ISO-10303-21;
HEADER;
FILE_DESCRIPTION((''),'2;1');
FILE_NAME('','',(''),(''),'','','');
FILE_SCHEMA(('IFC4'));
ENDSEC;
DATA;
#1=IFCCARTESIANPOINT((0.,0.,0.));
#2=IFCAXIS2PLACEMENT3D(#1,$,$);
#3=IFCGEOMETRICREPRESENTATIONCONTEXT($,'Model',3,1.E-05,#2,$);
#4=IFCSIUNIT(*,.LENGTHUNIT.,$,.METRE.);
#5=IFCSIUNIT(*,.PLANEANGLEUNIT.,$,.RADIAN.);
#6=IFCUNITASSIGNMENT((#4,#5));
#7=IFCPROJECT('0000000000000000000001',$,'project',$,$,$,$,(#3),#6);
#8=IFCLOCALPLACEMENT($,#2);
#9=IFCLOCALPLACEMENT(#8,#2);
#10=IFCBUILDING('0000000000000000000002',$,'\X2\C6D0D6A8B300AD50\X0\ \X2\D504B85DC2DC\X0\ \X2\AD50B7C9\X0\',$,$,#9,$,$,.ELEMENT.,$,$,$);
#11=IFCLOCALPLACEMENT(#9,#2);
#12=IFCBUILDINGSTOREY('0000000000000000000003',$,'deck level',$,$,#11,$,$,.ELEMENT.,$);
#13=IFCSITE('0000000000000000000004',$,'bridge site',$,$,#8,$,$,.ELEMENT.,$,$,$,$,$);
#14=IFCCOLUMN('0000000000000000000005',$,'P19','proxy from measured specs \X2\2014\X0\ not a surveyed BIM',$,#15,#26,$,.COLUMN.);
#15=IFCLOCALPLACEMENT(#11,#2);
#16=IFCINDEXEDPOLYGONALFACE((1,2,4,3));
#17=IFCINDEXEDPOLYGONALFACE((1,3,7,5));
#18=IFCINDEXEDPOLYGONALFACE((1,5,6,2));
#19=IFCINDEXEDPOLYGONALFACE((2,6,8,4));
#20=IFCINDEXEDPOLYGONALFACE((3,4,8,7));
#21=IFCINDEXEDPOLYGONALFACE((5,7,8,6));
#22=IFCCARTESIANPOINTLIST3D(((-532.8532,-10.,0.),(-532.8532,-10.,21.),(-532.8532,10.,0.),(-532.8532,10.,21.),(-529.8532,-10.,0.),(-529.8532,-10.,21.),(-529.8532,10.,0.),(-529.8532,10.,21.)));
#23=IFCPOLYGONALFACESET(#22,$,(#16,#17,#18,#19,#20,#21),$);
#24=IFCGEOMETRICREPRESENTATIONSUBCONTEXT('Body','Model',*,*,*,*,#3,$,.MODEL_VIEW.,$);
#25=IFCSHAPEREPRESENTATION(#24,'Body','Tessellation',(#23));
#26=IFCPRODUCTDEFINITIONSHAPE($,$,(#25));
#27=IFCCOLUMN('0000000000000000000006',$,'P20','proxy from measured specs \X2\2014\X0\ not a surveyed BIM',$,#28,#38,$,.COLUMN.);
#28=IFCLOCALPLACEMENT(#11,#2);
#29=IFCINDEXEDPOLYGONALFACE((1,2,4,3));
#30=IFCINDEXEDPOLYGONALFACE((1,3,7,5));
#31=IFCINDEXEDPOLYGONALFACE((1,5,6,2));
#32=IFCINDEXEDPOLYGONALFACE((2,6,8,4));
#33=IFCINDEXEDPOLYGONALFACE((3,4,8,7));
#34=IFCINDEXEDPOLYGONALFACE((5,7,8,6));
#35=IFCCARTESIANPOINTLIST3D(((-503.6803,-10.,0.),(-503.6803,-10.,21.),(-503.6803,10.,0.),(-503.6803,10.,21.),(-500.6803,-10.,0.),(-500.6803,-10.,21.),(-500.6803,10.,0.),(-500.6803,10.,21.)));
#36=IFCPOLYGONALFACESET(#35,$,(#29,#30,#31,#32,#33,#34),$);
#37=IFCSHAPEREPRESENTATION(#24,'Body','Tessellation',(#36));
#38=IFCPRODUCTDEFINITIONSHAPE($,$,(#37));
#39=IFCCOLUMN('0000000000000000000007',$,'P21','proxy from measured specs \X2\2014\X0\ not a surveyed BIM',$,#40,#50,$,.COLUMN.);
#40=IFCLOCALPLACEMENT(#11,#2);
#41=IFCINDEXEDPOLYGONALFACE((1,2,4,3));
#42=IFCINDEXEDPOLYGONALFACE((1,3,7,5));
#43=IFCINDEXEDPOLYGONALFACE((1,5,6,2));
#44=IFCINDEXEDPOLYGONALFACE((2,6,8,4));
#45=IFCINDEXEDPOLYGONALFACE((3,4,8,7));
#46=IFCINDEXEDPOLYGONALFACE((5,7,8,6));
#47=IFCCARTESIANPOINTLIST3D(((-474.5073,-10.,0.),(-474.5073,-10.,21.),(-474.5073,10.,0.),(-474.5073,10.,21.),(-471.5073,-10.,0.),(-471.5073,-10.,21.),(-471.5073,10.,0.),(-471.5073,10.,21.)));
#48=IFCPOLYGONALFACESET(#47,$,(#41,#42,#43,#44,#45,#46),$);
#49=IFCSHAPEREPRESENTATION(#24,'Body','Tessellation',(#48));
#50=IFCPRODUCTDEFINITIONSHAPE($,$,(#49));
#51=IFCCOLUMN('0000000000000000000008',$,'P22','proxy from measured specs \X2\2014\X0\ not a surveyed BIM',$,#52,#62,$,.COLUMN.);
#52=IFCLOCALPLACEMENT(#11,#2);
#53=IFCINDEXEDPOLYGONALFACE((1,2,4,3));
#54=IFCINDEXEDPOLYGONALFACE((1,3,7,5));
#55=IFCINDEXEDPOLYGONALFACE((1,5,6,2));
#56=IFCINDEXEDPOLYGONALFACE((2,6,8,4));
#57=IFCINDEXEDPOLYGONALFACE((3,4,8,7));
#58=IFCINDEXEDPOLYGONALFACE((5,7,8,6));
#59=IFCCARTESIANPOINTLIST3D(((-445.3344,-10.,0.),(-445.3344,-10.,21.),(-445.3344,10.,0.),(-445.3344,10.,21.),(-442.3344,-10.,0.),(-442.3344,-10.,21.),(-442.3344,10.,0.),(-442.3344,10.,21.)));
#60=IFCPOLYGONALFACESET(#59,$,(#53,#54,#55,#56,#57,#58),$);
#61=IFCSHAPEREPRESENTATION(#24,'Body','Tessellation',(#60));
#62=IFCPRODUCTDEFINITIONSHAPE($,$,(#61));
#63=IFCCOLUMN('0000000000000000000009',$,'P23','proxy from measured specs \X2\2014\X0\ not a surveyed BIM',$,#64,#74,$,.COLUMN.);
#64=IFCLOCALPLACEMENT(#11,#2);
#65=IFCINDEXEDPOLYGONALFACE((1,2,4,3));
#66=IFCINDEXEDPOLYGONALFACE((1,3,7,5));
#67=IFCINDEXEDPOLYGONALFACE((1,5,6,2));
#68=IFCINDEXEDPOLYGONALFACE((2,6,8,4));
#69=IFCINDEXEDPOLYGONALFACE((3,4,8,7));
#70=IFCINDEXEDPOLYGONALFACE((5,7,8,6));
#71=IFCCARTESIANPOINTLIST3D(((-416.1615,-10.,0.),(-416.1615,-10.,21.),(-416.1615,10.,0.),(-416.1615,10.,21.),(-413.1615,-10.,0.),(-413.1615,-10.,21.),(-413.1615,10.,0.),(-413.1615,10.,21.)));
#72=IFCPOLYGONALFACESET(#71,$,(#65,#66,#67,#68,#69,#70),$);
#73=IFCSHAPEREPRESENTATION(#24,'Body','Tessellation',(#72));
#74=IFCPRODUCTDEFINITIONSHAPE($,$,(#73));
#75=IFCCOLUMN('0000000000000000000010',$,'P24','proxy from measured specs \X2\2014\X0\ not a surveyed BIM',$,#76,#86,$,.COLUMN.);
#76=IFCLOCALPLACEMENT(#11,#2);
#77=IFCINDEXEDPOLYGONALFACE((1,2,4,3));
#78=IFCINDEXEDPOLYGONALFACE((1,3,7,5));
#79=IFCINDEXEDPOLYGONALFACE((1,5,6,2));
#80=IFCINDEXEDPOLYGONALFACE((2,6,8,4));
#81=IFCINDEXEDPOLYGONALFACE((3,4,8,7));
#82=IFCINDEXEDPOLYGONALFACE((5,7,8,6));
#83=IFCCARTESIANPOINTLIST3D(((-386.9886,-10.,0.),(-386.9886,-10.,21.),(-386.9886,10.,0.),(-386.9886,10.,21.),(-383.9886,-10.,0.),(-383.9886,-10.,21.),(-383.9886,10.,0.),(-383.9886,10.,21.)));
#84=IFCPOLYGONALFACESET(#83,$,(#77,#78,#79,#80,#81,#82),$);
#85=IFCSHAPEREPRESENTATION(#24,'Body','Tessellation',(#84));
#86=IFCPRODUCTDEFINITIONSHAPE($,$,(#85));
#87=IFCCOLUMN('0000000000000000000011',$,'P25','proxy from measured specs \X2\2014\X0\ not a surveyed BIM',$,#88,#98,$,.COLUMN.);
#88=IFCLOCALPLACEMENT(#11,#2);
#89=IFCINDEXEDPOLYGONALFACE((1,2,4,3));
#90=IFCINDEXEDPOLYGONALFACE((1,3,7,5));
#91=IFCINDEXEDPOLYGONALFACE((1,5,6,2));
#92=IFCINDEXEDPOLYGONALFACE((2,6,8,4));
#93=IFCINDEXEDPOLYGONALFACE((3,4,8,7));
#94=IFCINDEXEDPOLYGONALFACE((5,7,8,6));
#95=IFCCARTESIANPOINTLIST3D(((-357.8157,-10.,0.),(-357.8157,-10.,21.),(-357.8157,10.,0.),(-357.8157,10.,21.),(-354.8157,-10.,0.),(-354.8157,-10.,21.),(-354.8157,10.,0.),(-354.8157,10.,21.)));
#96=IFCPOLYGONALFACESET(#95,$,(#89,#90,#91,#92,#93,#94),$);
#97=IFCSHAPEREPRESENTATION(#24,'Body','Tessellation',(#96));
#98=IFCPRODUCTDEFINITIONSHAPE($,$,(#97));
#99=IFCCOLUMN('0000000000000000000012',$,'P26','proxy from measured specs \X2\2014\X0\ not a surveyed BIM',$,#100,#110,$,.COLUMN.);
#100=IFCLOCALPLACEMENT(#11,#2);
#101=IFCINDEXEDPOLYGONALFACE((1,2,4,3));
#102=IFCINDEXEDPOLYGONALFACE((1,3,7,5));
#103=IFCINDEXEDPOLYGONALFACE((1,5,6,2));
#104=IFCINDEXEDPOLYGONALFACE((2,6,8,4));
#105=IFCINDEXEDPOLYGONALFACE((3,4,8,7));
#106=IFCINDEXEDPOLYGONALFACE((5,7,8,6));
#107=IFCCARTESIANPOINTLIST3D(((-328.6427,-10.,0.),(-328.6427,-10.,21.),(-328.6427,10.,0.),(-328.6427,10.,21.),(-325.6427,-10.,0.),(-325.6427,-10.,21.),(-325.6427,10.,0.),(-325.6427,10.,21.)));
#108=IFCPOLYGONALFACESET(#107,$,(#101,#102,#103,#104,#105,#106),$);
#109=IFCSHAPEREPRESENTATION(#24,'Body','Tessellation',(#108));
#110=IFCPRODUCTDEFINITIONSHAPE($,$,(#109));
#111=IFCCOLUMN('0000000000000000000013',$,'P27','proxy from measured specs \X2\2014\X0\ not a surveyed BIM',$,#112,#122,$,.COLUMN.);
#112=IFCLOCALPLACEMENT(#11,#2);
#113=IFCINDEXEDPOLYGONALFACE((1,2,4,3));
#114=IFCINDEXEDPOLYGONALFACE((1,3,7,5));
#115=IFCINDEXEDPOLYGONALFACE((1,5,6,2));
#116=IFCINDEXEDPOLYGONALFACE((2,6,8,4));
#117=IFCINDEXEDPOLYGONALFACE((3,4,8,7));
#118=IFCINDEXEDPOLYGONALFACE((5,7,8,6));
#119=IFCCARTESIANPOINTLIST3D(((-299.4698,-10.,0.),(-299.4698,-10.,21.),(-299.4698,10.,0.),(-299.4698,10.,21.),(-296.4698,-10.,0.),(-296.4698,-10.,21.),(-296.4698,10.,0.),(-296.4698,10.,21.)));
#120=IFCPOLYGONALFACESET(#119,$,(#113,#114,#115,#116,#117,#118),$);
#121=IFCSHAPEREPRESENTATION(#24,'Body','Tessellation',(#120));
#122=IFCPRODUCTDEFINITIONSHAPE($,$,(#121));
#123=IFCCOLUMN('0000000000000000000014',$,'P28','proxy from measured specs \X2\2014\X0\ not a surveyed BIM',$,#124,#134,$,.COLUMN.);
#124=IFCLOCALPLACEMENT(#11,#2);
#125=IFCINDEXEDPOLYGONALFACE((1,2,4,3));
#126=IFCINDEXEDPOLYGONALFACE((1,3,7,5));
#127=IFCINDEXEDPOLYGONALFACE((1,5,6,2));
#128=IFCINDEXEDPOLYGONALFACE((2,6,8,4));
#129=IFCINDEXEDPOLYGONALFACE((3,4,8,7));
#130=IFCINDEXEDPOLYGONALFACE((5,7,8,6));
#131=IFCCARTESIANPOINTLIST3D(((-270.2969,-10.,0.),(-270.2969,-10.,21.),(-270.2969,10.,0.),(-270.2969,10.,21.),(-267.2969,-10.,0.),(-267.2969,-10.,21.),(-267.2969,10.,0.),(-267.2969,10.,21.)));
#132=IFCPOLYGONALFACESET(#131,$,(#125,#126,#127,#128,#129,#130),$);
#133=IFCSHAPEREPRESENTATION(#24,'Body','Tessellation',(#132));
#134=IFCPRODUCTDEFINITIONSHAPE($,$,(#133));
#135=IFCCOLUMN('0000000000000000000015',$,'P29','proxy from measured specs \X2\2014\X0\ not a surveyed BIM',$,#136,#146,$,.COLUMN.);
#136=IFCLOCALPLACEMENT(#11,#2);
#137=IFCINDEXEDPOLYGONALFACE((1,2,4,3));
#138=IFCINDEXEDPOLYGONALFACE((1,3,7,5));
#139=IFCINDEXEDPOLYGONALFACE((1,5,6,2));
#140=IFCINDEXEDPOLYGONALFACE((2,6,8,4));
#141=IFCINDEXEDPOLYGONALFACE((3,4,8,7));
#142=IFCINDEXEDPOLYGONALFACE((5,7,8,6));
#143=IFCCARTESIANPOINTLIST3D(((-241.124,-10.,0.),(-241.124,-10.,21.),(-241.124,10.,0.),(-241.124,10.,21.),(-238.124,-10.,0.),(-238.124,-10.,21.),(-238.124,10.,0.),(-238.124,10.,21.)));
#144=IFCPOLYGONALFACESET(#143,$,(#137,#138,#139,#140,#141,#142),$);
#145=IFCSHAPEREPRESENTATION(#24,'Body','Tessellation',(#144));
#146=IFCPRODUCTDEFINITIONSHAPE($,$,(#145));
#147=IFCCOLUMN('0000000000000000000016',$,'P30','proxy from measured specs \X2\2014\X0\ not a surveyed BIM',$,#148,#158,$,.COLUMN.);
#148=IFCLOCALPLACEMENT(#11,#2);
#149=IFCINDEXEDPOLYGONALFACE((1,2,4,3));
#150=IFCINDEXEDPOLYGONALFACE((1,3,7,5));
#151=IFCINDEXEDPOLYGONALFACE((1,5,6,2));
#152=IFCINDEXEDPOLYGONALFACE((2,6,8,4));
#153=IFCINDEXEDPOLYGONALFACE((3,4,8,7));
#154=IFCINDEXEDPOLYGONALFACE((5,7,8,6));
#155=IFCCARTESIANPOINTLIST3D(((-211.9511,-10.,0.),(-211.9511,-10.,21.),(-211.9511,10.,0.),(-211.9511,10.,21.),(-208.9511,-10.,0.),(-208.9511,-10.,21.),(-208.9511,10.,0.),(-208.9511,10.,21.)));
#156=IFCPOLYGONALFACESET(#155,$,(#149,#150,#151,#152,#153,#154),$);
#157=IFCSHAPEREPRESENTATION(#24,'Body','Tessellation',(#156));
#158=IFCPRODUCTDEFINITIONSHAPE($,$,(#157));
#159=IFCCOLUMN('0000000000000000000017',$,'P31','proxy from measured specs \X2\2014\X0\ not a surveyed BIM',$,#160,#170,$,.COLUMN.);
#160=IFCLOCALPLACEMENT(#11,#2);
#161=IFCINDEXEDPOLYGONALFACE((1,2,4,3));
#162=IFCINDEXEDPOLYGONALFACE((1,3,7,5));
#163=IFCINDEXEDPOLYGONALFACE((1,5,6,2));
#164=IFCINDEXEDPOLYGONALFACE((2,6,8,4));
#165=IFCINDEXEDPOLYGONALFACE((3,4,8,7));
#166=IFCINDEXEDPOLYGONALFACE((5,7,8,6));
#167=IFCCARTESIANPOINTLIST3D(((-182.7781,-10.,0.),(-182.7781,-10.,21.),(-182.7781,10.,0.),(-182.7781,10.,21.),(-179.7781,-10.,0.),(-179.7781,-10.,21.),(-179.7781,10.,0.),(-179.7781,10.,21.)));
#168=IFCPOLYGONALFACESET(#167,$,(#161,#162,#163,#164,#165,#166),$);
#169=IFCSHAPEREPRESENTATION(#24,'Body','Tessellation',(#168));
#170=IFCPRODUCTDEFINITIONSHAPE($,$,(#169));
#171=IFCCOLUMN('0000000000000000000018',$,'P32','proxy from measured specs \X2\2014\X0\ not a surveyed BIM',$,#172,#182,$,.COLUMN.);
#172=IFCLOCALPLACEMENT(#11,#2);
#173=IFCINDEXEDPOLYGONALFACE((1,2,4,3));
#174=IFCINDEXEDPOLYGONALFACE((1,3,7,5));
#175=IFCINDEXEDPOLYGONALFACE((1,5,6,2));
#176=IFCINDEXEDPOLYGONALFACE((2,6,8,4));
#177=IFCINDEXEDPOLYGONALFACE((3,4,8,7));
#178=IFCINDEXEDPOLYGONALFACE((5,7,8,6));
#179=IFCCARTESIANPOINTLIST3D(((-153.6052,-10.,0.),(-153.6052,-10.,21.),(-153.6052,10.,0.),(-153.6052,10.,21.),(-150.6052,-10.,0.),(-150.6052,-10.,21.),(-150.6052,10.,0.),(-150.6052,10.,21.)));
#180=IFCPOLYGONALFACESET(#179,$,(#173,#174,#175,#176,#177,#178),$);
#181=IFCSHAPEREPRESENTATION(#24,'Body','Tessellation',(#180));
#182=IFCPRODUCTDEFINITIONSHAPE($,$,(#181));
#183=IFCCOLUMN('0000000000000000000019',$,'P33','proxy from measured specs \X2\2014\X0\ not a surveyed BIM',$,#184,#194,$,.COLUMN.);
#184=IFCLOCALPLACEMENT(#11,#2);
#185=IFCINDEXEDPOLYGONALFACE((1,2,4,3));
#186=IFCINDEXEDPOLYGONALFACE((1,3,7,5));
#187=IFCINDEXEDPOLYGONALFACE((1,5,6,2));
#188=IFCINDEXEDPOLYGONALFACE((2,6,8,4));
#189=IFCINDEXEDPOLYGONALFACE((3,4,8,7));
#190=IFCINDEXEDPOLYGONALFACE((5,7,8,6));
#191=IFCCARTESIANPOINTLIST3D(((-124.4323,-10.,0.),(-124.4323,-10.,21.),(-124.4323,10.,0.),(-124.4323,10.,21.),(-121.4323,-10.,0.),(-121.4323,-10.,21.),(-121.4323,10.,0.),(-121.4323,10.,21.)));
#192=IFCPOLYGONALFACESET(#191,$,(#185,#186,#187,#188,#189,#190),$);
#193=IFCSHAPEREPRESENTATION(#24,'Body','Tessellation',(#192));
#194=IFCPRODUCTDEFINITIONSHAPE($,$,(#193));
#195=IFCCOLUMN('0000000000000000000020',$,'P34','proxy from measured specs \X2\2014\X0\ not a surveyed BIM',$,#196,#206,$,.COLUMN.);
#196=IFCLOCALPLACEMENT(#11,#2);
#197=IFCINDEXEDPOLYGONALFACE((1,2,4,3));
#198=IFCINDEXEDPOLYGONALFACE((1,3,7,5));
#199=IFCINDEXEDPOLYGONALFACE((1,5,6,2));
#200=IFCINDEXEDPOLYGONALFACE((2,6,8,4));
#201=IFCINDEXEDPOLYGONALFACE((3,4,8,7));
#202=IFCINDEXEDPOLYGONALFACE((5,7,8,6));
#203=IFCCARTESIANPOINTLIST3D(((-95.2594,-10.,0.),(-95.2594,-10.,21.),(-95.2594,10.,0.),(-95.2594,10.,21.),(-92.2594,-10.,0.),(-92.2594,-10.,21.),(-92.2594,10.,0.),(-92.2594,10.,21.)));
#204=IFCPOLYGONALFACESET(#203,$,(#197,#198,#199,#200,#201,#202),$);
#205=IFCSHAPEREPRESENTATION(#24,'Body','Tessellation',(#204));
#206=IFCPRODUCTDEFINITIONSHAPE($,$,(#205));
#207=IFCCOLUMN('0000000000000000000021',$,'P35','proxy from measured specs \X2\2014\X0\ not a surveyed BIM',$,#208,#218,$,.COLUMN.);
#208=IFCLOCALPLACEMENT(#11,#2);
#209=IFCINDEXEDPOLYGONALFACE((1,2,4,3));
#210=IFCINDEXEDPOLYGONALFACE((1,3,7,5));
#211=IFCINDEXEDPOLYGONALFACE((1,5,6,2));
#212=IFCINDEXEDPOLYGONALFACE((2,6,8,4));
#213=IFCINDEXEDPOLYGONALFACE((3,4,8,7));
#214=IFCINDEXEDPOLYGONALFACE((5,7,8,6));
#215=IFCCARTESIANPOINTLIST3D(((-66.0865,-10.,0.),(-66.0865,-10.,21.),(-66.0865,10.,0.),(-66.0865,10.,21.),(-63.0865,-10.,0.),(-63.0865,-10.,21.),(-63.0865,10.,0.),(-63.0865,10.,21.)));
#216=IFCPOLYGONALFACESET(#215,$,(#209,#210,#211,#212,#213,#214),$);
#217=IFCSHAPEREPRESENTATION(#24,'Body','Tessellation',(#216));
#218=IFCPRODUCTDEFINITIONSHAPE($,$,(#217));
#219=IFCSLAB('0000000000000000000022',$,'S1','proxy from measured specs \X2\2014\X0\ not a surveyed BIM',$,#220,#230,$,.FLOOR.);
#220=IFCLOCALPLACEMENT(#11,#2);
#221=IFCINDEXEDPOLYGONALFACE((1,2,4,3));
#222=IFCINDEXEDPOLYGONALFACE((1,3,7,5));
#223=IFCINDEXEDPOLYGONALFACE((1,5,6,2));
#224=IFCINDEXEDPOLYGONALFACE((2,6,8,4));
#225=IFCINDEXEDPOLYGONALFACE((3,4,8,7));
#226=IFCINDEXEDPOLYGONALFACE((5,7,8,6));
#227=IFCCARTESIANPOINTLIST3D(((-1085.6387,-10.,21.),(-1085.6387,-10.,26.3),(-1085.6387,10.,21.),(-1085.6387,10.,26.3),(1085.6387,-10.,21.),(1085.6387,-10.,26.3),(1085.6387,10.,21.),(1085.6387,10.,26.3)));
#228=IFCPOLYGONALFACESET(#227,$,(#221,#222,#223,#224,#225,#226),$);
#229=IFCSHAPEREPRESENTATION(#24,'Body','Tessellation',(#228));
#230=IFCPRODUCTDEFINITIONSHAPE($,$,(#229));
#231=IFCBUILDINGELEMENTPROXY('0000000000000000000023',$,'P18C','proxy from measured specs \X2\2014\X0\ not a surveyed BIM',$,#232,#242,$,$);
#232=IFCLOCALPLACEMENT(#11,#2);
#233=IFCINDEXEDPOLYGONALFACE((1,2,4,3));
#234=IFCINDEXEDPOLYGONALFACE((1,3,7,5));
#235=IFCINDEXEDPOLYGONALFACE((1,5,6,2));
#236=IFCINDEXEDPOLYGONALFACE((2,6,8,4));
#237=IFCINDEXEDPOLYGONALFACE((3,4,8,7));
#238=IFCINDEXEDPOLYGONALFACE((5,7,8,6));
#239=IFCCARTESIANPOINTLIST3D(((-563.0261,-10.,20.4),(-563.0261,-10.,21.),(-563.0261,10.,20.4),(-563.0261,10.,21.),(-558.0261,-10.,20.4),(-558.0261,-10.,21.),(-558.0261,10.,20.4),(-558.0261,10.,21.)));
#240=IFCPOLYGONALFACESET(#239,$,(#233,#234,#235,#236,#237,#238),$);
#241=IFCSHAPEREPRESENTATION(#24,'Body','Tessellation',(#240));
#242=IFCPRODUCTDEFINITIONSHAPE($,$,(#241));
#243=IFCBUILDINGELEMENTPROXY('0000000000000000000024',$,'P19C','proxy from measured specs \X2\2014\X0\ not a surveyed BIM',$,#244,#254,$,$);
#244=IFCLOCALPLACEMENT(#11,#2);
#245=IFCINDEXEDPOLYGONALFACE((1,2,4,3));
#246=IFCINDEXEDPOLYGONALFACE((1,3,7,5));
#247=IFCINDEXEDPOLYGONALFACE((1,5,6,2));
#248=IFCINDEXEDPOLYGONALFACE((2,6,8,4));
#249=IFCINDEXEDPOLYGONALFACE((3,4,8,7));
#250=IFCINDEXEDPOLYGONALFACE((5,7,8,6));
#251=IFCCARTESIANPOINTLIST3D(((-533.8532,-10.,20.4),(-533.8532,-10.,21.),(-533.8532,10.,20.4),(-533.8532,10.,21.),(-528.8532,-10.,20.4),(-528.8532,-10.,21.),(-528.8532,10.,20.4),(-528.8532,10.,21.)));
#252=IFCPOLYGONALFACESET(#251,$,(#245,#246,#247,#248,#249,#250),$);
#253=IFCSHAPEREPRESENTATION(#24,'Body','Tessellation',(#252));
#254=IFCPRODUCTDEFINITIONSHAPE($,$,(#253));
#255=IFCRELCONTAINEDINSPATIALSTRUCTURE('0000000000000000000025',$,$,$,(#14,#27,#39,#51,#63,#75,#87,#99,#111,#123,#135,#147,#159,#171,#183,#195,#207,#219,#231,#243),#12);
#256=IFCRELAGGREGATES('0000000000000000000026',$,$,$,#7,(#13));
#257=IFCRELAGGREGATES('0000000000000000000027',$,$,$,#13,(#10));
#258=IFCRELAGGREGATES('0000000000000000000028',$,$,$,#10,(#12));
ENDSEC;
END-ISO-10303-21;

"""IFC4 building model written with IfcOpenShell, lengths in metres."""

from ifc_helpers import new_model, si_unit, frame, origin, origin_2d, place, context, subcontext, project, spatial, rectangle, extrude, element, save


model = new_model("IFC4")

# Units and contexts
model_context = context("Model", 3, precision=1e-05, world=origin())
body_context = subcontext(model_context, "Body", "Model", "MODEL_VIEW")
ifc_project = project(units=[si_unit("LENGTHUNIT", "METRE"), si_unit("PLANEANGLEUNIT", "RADIAN")], contexts=[model_context])

# Site, building, storey
site_placement = place(None, origin())
site = spatial("IfcSite", under=ifc_project, at=site_placement, Name="bridge site", CompositionType="ELEMENT")
building_placement = place(site_placement, origin())
building = spatial("IfcBuilding", under=site, at=building_placement, Name="원효대교 프록시 교량", CompositionType="ELEMENT")
storey_placement = place(building_placement, origin())
storey = spatial("IfcBuildingStorey", under=building, at=storey_placement, Name="deck level", CompositionType="ELEMENT")

# Columns
for number, where, name in (
    (1, (-531.3532, 0.0, 0.0), "P19"),
    (2, (-502.1803, 0.0, 0.0), "P20"),
    (3, (-473.0073, 0.0, 0.0), "P21"),
    (4, (-443.8344, 0.0, 0.0), "P22"),
    (5, (-414.6615, 0.0, 0.0), "P23"),
    (6, (-385.4886, 0.0, 0.0), "P24"),
    (7, (-356.3157, 0.0, 0.0), "P25"),
    (8, (-327.1427, 0.0, 0.0), "P26"),
    (9, (-297.9698, 0.0, 0.0), "P27"),
    (10, (-268.7969, 0.0, 0.0), "P28"),
    (11, (-239.624, 0.0, 0.0), "P29"),
    (12, (-210.4511, 0.0, 0.0), "P30"),
    (13, (-181.2781, 0.0, 0.0), "P31"),
    (14, (-152.1052, 0.0, 0.0), "P32"),
    (15, (-122.9323, 0.0, 0.0), "P33"),
    (16, (-93.7594, 0.0, 0.0), "P34"),
    (17, (-64.5865, 0.0, 0.0), "P35"),
):
    element("IfcColumn", number, at=place(storey_placement, frame(where)), inside=storey, Name=name, Description="proxy from measured specs — not a surveyed BIM", PredefinedType="COLUMN", context=body_context, shape_type="SweptSolid", body=[
        extrude(rectangle(XDim=3.0, YDim=20.0, at=origin_2d()), origin(), (0.0, 0.0, 1.0), 21.0),
    ])

# Slab
slab_placement = place(storey_placement, frame((0.0, 0.0, 21.0)))
element("IfcSlab", 18, at=slab_placement, inside=storey, Name="S1", Description="proxy from measured specs — not a surveyed BIM", PredefinedType="FLOOR", context=body_context, shape_type="SweptSolid", body=[
    extrude(rectangle(XDim=2171.2773, YDim=20.0, at=origin_2d()), origin(), (0.0, 0.0, 1.0), 5.3),
])

# Building element proxies
for number, where, name in (
    (19, (-560.5261, 0.0, 20.4), "P18C"),
    (20, (-531.3532, 0.0, 20.4), "P19C"),
):
    element("IfcBuildingElementProxy", number, at=place(storey_placement, frame(where)), inside=storey, Name=name, Description="proxy from measured specs — not a surveyed BIM", context=body_context, shape_type="SweptSolid", body=[
        extrude(rectangle(XDim=5.0, YDim=20.0, at=origin_2d()), origin(), (0.0, 0.0, 1.0), 0.6),
    ])

save(model, "model.ifc")
